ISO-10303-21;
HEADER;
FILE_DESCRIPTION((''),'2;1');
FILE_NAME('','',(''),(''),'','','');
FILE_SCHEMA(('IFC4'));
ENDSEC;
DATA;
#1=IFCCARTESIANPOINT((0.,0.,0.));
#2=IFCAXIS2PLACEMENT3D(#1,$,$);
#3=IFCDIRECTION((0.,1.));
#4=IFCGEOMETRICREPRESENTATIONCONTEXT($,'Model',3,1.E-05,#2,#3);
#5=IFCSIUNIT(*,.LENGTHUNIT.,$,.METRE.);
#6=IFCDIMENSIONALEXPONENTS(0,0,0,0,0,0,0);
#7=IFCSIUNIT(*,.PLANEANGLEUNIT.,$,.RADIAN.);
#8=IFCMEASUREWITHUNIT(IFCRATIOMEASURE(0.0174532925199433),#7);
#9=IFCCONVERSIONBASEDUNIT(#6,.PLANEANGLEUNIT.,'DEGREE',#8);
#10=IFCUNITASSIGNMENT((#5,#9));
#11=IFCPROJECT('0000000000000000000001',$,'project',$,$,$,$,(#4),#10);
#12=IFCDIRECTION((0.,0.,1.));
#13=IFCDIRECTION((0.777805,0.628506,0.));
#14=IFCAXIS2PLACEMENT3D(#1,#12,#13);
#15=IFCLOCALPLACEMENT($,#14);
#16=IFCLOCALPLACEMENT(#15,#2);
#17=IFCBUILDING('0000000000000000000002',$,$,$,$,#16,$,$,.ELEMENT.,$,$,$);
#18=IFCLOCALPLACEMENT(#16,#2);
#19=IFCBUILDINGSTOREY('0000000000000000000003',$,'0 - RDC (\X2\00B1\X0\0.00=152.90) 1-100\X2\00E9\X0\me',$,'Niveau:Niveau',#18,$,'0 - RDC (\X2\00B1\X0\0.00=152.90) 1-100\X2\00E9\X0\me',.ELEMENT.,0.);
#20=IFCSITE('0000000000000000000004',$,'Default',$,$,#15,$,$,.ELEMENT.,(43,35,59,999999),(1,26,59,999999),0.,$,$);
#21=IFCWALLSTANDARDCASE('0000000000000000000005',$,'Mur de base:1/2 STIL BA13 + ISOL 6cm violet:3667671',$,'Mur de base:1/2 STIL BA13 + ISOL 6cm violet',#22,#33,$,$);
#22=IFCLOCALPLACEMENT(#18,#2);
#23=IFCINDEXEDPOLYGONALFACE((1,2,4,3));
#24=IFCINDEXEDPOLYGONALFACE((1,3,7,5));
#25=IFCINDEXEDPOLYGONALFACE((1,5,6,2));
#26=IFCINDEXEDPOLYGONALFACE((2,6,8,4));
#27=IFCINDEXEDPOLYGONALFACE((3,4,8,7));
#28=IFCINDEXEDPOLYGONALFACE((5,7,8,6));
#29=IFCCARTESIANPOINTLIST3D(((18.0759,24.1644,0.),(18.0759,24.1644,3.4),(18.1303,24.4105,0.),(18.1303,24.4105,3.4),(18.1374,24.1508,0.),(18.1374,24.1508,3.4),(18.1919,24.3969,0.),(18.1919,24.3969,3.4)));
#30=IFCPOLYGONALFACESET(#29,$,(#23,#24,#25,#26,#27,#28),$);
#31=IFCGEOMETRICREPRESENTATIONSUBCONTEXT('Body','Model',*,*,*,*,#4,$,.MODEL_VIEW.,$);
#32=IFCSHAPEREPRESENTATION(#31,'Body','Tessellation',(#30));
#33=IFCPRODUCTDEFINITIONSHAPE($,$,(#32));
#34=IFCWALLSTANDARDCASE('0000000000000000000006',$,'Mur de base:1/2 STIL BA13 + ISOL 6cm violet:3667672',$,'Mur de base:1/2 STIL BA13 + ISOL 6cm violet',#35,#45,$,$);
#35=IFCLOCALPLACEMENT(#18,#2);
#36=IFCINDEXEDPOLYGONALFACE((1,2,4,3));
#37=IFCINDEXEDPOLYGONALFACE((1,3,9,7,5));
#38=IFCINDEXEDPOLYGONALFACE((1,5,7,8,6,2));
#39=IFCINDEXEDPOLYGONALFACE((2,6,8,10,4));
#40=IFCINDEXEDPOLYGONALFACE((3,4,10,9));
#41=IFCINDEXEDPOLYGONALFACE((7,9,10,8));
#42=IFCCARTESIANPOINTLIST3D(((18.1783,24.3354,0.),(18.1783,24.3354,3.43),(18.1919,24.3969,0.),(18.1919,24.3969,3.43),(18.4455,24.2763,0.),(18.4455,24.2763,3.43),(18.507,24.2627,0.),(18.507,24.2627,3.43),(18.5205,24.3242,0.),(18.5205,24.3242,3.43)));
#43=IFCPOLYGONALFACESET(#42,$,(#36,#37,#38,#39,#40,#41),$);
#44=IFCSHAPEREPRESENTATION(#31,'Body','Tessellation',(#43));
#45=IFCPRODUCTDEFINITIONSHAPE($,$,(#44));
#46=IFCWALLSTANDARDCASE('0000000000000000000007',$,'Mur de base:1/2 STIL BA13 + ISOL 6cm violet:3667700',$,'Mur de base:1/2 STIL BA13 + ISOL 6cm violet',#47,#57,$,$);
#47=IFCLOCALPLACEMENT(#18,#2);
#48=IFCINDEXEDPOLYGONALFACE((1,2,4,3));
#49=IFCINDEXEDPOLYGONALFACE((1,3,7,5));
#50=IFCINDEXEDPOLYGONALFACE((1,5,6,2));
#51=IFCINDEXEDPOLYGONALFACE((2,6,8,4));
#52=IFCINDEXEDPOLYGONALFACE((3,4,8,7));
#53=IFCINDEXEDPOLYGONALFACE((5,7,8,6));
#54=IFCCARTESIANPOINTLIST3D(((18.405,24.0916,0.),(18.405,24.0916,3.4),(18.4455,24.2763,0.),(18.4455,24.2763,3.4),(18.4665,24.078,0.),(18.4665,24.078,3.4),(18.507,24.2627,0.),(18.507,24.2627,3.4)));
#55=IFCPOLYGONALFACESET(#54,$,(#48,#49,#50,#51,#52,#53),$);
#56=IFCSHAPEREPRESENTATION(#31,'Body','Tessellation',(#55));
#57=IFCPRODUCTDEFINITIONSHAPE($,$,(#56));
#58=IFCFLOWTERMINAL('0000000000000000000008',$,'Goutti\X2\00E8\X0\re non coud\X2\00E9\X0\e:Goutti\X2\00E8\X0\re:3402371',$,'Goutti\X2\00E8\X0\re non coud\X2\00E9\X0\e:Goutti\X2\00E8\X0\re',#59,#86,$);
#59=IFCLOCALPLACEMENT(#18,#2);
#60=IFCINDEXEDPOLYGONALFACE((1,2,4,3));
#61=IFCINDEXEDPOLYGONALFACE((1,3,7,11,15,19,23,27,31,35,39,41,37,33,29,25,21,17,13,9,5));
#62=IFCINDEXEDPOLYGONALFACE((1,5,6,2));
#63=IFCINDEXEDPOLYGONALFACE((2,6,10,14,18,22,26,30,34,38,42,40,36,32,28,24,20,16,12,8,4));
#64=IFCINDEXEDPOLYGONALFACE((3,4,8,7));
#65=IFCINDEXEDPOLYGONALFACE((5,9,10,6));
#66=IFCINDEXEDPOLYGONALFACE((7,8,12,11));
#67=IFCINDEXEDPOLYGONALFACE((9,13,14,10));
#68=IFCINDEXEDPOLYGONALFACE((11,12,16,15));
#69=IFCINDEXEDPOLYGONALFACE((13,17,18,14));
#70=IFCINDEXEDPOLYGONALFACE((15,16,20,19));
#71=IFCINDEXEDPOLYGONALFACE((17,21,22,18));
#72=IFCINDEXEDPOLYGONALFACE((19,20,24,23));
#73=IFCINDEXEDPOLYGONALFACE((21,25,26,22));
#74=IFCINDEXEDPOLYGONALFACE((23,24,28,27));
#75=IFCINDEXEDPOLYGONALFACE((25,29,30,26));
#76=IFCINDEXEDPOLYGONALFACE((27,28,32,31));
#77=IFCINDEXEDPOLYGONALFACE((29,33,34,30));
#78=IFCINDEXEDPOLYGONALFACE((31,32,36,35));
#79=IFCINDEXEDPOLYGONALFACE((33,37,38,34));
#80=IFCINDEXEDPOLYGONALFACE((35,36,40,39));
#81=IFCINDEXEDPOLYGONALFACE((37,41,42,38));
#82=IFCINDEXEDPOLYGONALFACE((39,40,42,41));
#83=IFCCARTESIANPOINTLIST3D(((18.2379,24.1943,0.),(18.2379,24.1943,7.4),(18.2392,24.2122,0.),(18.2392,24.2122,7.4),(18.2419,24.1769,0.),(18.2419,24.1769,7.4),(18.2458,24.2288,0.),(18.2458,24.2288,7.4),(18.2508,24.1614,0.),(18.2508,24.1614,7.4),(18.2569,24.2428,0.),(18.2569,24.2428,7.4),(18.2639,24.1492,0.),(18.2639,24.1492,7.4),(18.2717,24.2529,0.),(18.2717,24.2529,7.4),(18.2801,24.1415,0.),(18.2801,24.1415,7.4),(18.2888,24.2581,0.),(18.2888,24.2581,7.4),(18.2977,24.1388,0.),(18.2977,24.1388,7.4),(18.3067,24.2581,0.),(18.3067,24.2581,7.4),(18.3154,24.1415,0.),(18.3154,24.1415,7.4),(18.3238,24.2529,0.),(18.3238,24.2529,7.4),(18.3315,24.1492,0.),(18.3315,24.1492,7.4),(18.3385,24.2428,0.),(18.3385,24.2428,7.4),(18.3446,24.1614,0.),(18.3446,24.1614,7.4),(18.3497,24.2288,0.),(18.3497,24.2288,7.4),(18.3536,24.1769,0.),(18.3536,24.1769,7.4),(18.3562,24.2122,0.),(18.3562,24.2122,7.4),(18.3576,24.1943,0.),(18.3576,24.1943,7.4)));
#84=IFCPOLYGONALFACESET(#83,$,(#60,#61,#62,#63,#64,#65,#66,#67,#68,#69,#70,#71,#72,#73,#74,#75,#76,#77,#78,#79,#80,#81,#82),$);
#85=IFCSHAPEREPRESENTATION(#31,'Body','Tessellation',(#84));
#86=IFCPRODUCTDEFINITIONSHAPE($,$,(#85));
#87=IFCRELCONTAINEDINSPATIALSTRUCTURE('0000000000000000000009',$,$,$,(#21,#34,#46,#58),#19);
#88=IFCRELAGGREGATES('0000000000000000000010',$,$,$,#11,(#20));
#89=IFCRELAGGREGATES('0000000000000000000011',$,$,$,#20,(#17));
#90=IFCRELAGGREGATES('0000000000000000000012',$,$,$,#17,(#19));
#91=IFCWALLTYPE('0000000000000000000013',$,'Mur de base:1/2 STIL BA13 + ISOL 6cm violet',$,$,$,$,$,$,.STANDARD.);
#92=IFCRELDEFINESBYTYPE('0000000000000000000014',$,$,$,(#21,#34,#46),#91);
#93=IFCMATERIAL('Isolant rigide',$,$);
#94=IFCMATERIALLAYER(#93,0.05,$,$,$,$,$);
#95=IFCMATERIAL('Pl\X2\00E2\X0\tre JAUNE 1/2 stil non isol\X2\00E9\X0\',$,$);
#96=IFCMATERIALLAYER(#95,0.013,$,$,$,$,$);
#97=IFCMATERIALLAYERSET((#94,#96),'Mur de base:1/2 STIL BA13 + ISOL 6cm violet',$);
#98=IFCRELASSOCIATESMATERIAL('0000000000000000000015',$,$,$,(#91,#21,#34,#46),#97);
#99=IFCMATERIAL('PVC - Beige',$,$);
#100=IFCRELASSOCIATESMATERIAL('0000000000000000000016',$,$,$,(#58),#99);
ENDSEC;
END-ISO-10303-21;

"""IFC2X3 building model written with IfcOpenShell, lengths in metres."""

from ifc_helpers import new_model, entity, si_unit, converted_unit, direction, frame, frame_2d, origin, place, context, subcontext, project, spatial, polyline, rectangle, circle, outline, extrude, source, transform, mapped, material, layer, layer_set, layer_usage, type_object, element, save


model = new_model("IFC2X3")

# Units and contexts
model_context = context("Model", 3, precision=1e-05, world=origin(), true_north=direction((0.0, 1.0)))
body_context = subcontext(model_context, "Body", "Model", "MODEL_VIEW")
ifc_project = project(units=[si_unit("LENGTHUNIT", "METRE"), converted_unit("PLANEANGLEUNIT", "DEGREE", entity("IfcRatioMeasure", 0.0174532925199433), si_unit("PLANEANGLEUNIT", "RADIAN"), dimensions=[0, 0, 0, 0, 0, 0, 0])], contexts=[model_context])

# Site, building, storey
site_placement = place(None, frame((0.0, 0.0, 0.0), z_axis=(0.0, 0.0, 1.0), x_axis=(0.777805, 0.628506, 0.0)))
site = spatial("IfcSite", under=ifc_project, at=site_placement, Name="Default", CompositionType="ELEMENT", RefLatitude=(43, 35, 59, 999999), RefLongitude=(1, 26, 59, 999999), RefElevation=0.0)
building_placement = place(site_placement, origin())
building = spatial("IfcBuilding", under=site, at=building_placement, CompositionType="ELEMENT")
storey_placement = place(building_placement, origin())
storey = spatial("IfcBuildingStorey", under=building, at=storey_placement, Name="0 - RDC (±0.00=152.90) 1-100éme", ObjectType="Niveau:Niveau", LongName="0 - RDC (±0.00=152.90) 1-100éme", CompositionType="ELEMENT", Elevation=0.0)

# Walls
ifc_material_1 = material(Name="Plâtre JAUNE 1/2 stil non isolé")
ifc_material_2 = material(Name="Isolant rigide")
ifc_layer_1 = layer(ifc_material_2, 0.05)
ifc_layer_2 = layer(ifc_material_1, 0.013)
ifc_layer_set_1 = layer_set([ifc_layer_1, ifc_layer_2], Name="Mur de base:1/2 STIL BA13 + ISOL 6cm violet")
ifc_layer_usage_1 = layer_usage(ifc_layer_set_1, "AXIS2", "POSITIVE", -0.0315)
wall_type_1 = type_object("IfcWallType", Name="Mur de base:1/2 STIL BA13 + ISOL 6cm violet", PredefinedType="STANDARD", material=ifc_layer_set_1)
wall_1_placement = place(storey_placement, frame((18.1067, 24.1576, 0.0), z_axis=(0.0, 0.0, 1.0), x_axis=(0.2159, 0.976415, 0.0)))
element("IfcWallStandardCase", 1, at=wall_1_placement, inside=storey, type_object=wall_type_1, material=ifc_layer_usage_1, Name="Mur de base:1/2 STIL BA13 + ISOL 6cm violet:3667671", ObjectType="Mur de base:1/2 STIL BA13 + ISOL 6cm violet", context=body_context, shape_type="SweptSolid", body=[
    extrude(rectangle(XDim=0.2521, YDim=0.063, at=frame_2d((0.126, 0.0), x_axis=(-1.0, 0.0))), origin(), (0.0, 0.0, 1.0), 3.4),
])
ifc_layer_usage_2 = layer_usage(ifc_layer_set_1, "AXIS2", "POSITIVE", -0.0315)
wall_2_placement = place(storey_placement, frame((18.1851, 24.3661, 0.0), z_axis=(0.0, 0.0, 1.0), x_axis=(0.976415, -0.2159, 0.0)))
element("IfcWallStandardCase", 2, at=wall_2_placement, inside=storey, type_object=wall_type_1, material=ifc_layer_usage_2, Name="Mur de base:1/2 STIL BA13 + ISOL 6cm violet:3667672", ObjectType="Mur de base:1/2 STIL BA13 + ISOL 6cm violet", context=body_context, shape_type="SweptSolid", body=[
    extrude(outline(polyline([(0.3367, -0.0315), (0.3366, 0.0315), (0.0, 0.0315), (0.0, -0.0315), (0.2737, -0.0315), (0.3367, -0.0315)])), origin(), (0.0, 0.0, 1.0), 3.43),
])
ifc_layer_usage_3 = layer_usage(ifc_layer_set_1, "AXIS2", "NEGATIVE", 0.0315)
wall_3_placement = place(storey_placement, frame((18.4357, 24.0847, 0.0), z_axis=(0.0, 0.0, 1.0), x_axis=(0.21428, 0.976772, 0.0)))
element("IfcWallStandardCase", 3, at=wall_3_placement, inside=storey, type_object=wall_type_1, material=ifc_layer_usage_3, Name="Mur de base:1/2 STIL BA13 + ISOL 6cm violet:3667700", ObjectType="Mur de base:1/2 STIL BA13 + ISOL 6cm violet", context=body_context, shape_type="SweptSolid", body=[
    extrude(outline(polyline([(0.1891, -0.0315), (0.1892, 0.0315), (0.0001, 0.0315), (0.0, -0.0315), (0.1891, -0.0315)])), origin(), (0.0, 0.0, 1.0), 3.4),
])

# Flow terminal
ifc_material_3 = material(Name="PVC - Beige")
shared_shape_1 = source(origin(), body_context, "Body", "SweptSolid", [
    extrude(circle(Radius=0.06, at=frame_2d((0.0, 0.0), x_axis=(1.0, 0.0))), frame((0.0, 0.0, 0.0), z_axis=(0.0, 0.0, 1.0), x_axis=(0.0, -1.0, 0.0)), (0.0, 0.0, 1.0), 7.4),
])
flow_terminal_placement = place(storey_placement, frame((18.2977, 24.1988, 0.0)))
element("IfcFlowTerminal", 4, at=flow_terminal_placement, inside=storey, material=ifc_material_3, Name="Gouttière non coudée:Gouttière:3402371", ObjectType="Gouttière non coudée:Gouttière", context=body_context, shape_type="MappedRepresentation", body=[
    mapped(shared_shape_1, transform((0.0, 0.0, 0.0), scale=1.0)),
])

save(model, "model.ifc")
